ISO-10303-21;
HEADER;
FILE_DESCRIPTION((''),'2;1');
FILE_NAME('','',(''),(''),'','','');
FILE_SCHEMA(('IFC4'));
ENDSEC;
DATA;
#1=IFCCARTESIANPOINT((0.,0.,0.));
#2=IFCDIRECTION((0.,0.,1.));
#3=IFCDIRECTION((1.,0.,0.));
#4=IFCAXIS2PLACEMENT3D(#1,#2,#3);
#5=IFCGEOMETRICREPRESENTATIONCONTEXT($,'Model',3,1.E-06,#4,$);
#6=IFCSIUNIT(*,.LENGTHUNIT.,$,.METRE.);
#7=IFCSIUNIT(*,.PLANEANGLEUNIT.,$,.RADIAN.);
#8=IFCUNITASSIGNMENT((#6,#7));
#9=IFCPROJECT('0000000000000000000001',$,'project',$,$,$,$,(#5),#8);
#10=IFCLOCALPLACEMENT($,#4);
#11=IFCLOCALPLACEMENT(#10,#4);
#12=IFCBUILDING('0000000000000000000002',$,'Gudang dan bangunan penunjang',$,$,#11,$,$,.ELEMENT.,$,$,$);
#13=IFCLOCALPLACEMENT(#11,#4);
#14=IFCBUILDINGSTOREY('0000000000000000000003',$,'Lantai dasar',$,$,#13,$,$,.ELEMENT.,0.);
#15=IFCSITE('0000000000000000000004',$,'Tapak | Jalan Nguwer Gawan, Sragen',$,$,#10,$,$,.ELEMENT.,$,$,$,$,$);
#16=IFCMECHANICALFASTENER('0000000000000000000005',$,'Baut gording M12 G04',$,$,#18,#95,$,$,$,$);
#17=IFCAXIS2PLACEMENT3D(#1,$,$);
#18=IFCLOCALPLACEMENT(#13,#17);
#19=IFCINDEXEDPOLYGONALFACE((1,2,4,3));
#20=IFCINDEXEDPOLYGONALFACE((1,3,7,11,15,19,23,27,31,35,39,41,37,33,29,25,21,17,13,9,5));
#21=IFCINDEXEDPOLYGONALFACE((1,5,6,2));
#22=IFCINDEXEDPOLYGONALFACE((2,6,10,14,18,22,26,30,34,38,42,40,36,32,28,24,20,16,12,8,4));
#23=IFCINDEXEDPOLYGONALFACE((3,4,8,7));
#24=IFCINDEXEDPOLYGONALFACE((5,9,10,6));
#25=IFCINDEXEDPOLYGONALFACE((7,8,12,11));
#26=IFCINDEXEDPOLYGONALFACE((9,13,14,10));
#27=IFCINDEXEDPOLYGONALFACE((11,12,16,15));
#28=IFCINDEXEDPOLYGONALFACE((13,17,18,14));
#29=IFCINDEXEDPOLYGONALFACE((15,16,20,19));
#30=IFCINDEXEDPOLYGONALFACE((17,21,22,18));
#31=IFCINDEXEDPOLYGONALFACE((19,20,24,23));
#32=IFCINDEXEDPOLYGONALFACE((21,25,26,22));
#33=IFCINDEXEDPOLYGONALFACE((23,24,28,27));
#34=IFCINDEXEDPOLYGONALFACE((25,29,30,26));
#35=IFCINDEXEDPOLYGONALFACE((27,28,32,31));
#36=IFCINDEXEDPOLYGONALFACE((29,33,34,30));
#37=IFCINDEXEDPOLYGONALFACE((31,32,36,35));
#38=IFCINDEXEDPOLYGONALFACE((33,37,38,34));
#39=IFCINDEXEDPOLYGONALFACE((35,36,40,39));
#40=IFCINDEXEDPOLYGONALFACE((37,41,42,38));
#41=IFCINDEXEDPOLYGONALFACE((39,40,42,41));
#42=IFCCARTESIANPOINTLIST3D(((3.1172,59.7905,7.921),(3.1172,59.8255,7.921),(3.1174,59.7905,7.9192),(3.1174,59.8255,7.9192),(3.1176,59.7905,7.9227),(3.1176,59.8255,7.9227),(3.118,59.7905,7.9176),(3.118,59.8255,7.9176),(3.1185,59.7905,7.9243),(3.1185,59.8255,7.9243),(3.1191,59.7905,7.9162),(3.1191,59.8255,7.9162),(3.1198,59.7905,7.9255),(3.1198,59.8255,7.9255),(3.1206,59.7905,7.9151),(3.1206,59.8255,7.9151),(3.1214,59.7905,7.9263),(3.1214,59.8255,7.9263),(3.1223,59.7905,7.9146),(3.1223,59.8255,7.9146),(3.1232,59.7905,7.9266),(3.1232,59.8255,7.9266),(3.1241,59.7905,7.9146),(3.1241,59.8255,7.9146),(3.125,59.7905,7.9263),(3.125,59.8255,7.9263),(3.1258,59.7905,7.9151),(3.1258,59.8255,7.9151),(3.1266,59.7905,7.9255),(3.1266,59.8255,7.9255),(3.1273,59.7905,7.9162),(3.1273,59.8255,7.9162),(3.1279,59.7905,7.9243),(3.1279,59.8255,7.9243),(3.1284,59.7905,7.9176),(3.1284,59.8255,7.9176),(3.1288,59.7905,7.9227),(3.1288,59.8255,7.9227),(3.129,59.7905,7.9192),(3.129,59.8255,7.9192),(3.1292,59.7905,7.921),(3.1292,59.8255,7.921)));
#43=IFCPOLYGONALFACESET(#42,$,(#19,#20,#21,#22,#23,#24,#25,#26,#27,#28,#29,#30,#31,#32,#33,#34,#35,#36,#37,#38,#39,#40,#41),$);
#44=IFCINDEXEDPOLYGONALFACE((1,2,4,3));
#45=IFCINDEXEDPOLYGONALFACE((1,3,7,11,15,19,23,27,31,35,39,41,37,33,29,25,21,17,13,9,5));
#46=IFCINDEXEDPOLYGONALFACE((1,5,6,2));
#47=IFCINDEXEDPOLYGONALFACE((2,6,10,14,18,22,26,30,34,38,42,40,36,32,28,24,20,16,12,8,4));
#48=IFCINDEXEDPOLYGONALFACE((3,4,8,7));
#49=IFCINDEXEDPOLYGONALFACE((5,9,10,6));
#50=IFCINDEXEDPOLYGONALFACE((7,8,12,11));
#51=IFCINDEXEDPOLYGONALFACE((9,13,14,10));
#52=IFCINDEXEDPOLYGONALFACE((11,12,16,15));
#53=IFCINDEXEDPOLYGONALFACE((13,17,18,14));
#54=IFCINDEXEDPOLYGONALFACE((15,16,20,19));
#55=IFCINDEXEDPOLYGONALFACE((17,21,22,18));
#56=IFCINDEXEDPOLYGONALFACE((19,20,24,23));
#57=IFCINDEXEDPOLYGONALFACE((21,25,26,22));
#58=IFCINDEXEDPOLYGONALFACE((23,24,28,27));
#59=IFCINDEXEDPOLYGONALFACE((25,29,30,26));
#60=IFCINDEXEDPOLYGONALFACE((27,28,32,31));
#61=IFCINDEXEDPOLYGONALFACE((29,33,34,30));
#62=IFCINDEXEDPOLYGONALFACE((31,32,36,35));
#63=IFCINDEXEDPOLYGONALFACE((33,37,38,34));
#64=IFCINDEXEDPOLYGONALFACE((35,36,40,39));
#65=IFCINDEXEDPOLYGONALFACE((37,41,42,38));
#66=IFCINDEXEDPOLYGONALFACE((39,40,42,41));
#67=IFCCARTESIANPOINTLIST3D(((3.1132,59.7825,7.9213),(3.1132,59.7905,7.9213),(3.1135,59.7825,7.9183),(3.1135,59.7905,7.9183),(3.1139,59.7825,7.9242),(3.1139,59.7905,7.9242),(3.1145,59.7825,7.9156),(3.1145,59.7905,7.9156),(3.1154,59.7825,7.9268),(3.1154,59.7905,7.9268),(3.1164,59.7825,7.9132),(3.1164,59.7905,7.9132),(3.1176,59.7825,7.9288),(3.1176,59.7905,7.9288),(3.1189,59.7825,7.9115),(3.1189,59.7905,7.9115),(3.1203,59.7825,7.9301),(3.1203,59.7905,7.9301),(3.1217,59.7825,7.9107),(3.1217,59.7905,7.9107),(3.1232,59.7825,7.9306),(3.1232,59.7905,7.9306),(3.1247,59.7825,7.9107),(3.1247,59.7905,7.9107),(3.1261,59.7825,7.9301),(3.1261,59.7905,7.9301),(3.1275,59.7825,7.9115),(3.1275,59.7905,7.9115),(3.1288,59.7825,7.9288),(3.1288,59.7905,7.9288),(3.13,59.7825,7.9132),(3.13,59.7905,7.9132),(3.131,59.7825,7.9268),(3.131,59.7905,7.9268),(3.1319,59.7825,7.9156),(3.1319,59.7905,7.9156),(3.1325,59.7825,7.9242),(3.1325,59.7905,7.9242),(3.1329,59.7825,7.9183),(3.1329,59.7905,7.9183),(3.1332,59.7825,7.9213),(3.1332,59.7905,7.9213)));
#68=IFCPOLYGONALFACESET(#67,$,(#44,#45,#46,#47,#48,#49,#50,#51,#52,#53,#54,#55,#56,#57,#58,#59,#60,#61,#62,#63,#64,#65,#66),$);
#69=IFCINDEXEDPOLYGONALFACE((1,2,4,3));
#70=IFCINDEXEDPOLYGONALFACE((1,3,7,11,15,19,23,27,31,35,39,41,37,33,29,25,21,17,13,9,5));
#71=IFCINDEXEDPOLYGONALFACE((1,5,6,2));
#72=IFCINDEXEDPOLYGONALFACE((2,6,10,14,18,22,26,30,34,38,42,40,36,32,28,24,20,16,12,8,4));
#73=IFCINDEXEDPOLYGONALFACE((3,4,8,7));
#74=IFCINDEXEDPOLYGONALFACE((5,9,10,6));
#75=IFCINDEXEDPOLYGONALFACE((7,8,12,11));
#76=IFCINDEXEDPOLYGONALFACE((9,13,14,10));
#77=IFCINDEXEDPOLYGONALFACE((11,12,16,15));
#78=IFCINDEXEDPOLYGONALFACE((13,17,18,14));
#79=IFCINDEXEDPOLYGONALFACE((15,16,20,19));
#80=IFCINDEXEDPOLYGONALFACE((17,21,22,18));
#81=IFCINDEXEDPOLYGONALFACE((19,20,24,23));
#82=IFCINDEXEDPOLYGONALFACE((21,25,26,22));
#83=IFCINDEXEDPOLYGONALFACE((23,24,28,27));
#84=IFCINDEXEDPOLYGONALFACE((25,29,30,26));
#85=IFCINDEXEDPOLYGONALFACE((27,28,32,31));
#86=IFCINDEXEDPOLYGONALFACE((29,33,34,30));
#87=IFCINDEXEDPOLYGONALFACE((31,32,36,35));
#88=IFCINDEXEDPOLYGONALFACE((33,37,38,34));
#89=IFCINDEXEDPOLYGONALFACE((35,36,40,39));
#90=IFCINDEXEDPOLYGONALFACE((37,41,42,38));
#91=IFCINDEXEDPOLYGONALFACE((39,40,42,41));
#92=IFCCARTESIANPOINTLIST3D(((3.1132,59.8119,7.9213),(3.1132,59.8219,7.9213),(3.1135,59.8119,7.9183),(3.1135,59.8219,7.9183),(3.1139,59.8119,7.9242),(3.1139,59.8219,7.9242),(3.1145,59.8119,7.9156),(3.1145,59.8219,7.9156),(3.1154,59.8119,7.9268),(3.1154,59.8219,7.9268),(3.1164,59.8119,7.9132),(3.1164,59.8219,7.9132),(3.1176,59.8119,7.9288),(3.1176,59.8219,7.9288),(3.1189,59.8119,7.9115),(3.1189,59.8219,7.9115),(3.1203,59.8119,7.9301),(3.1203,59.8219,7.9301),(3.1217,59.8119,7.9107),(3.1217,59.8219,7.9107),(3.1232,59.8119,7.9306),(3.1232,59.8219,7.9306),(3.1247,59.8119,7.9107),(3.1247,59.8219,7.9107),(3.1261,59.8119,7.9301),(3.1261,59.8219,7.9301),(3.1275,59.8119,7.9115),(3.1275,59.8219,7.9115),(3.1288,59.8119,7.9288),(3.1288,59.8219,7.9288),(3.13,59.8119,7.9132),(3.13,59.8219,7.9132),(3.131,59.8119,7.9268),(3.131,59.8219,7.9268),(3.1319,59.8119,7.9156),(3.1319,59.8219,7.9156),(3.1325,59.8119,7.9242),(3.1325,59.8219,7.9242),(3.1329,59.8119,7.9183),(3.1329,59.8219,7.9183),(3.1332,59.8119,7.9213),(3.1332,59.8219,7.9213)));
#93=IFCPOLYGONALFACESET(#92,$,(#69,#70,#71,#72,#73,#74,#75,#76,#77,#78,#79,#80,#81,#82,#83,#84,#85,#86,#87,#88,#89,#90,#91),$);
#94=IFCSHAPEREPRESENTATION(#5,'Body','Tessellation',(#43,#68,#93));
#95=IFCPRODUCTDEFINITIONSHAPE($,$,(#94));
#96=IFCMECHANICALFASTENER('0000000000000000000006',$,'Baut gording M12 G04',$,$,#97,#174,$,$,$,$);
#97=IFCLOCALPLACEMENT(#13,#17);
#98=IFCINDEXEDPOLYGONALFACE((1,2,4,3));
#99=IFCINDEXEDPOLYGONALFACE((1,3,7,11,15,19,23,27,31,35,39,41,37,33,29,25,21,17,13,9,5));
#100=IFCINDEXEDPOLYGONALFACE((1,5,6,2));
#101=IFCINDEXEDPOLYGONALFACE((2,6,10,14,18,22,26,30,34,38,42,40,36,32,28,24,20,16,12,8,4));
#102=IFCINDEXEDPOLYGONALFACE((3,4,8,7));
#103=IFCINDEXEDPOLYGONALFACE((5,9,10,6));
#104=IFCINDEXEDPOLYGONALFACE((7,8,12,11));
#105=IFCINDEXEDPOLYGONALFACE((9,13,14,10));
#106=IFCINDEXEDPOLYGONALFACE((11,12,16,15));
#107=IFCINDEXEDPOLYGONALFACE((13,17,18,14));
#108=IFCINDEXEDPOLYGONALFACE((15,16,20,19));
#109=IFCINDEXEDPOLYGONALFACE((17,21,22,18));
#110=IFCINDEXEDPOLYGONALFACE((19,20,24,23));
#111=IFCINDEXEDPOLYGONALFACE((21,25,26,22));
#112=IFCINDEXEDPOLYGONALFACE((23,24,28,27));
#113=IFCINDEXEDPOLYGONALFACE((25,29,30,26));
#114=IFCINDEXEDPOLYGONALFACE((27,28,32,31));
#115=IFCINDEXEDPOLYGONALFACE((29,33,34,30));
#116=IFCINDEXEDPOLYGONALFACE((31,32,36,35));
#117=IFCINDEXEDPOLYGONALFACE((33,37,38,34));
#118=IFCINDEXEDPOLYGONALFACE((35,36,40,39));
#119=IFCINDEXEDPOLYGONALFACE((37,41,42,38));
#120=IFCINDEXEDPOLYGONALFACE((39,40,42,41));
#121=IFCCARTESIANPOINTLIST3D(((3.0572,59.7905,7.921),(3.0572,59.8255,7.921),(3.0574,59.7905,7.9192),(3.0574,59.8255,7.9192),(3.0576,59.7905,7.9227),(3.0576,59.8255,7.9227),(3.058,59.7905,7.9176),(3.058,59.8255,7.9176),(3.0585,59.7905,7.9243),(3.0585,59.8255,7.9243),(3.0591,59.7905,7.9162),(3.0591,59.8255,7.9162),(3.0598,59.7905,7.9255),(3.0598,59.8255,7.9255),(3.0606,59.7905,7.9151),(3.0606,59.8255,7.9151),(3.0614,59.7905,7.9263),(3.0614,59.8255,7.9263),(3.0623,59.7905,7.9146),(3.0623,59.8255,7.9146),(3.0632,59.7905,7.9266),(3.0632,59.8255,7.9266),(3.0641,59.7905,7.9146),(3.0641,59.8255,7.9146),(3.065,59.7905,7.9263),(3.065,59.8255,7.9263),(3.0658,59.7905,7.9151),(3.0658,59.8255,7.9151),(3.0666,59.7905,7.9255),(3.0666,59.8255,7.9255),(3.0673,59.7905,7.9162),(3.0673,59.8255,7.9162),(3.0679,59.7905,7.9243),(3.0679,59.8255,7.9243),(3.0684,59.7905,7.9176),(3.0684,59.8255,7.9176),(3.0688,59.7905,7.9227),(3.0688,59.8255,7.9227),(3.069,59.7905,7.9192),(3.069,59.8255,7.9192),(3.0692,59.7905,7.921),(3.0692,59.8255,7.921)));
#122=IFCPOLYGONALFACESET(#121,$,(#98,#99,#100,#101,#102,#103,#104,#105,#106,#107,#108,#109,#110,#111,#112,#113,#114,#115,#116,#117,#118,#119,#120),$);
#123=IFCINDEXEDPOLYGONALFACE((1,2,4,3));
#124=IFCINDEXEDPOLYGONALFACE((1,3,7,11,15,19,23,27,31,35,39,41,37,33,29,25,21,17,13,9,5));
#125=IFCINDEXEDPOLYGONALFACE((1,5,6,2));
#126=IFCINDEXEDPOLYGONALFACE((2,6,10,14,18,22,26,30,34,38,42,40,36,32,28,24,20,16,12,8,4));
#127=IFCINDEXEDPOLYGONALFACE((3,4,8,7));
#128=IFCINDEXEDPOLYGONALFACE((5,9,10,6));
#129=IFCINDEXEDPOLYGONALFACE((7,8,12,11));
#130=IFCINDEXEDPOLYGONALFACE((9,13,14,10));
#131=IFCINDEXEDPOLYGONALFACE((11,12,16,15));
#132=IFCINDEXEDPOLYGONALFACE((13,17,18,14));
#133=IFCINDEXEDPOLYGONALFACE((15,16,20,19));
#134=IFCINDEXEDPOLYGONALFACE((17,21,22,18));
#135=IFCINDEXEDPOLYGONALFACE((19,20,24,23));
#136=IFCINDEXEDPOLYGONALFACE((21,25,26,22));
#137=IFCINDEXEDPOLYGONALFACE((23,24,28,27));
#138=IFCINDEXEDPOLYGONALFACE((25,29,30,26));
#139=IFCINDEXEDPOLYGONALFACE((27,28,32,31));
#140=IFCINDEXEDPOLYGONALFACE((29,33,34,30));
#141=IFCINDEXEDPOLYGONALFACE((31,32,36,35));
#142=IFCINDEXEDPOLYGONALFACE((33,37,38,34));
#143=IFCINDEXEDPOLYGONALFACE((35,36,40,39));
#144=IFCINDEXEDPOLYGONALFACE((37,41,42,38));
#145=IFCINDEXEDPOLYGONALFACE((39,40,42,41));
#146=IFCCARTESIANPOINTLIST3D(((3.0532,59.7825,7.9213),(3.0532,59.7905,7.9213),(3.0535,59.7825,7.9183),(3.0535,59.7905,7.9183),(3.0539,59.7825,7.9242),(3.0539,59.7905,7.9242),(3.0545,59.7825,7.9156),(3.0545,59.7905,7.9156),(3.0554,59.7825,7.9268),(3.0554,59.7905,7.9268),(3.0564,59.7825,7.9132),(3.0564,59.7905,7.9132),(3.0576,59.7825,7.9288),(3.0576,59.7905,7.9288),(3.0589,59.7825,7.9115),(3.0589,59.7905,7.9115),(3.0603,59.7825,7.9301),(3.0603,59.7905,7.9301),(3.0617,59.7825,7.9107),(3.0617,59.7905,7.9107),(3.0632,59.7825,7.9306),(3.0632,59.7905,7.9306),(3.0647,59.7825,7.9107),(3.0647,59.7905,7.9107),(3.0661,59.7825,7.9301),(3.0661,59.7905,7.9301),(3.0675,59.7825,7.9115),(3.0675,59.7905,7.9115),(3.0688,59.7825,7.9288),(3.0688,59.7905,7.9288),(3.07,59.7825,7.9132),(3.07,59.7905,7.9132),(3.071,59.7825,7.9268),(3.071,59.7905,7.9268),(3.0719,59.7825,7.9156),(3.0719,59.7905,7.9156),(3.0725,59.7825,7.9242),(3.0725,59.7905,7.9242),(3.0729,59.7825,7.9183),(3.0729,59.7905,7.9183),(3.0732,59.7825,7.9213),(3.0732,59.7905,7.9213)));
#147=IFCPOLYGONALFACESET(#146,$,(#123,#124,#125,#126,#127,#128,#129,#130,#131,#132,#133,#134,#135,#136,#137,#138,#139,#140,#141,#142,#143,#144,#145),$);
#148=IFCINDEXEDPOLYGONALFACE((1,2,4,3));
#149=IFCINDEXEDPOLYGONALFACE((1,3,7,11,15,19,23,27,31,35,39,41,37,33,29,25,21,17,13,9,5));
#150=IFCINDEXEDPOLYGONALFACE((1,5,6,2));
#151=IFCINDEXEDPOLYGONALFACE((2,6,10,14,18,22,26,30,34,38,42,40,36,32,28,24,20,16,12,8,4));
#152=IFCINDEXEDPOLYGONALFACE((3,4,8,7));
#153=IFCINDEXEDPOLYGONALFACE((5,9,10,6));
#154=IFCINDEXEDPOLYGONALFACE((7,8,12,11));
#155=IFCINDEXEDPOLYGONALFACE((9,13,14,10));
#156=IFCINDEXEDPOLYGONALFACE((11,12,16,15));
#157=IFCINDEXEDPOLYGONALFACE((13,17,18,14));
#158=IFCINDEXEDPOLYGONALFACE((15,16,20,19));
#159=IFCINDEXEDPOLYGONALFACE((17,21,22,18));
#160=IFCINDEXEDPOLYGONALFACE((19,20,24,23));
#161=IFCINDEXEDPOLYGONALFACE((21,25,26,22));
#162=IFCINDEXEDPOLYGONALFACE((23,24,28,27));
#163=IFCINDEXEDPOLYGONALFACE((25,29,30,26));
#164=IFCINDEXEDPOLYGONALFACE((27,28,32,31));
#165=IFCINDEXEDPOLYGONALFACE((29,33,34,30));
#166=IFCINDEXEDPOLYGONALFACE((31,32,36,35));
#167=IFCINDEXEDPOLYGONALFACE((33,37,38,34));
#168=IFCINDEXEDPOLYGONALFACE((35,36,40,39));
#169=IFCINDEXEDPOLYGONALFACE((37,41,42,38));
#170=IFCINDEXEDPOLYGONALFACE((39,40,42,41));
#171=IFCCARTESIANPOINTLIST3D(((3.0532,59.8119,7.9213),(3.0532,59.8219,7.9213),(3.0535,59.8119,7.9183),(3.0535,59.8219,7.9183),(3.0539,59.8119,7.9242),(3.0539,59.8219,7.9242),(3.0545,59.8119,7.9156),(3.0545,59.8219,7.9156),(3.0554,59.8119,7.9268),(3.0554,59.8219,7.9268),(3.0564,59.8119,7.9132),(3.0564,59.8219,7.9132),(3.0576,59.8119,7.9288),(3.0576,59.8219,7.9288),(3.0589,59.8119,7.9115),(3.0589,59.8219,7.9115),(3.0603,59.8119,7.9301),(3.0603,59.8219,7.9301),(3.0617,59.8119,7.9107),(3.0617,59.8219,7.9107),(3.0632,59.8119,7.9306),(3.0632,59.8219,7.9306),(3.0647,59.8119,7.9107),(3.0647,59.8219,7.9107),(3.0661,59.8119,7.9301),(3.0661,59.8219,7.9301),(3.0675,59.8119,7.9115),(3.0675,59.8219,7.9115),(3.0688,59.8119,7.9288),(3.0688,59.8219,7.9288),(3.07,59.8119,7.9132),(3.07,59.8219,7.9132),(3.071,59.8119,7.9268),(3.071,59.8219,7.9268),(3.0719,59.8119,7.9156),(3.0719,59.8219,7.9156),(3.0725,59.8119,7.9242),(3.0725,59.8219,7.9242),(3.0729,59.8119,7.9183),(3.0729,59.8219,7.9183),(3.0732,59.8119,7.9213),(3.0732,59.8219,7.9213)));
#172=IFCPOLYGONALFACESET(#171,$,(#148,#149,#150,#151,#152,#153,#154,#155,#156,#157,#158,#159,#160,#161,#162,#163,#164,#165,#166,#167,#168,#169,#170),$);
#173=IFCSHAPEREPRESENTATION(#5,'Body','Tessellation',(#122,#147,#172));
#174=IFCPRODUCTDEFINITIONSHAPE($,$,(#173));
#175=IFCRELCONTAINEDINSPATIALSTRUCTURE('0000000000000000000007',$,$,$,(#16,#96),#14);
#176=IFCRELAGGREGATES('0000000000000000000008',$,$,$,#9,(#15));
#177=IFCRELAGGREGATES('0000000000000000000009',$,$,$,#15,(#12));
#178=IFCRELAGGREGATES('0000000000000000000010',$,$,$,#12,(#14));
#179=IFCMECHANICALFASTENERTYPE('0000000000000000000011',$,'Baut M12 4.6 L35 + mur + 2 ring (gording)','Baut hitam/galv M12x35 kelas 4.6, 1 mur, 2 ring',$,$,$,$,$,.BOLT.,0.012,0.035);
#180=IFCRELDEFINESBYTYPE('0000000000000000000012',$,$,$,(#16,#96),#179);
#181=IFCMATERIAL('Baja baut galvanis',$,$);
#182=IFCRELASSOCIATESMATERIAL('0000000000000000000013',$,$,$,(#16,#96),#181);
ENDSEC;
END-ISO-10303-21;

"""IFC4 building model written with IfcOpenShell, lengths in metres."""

from ifc_helpers import new_model, si_unit, frame, origin_with_axes, place, context, project, spatial, circle, extrude, source, transform, mapped, material, type_object, type_shapes, element, save


model = new_model("IFC4")

# Units and contexts
model_context = context("Model", 3, precision=1e-06, world=origin_with_axes())
ifc_project = project(units=[si_unit("LENGTHUNIT", "METRE"), si_unit("PLANEANGLEUNIT", "RADIAN")], contexts=[model_context])

# Site, building, storey
site_placement = place(None, origin_with_axes())
site = spatial("IfcSite", under=ifc_project, at=site_placement, Name="Tapak | Jalan Nguwer Gawan, Sragen", CompositionType="ELEMENT")
building_placement = place(site_placement, origin_with_axes())
building = spatial("IfcBuilding", under=site, at=building_placement, Name="Gudang dan bangunan penunjang", CompositionType="ELEMENT")
storey_placement = place(building_placement, origin_with_axes())
storey = spatial("IfcBuildingStorey", under=building, at=storey_placement, Name="Lantai dasar", CompositionType="ELEMENT", Elevation=0.0)

# Shared definitions
placement = place(None, origin_with_axes())

# Mechanical fasteners
ifc_material_1 = material(Name="Baja baut galvanis")
mechanical_fastener_type = type_object("IfcMechanicalFastenerType", Name="Baut M12 4.6 L35 + mur + 2 ring (gording)", Description="Baut hitam/galv M12x35 kelas 4.6, 1 mur, 2 ring", NominalDiameter=0.012, NominalLength=0.035, PredefinedType="BOLT")
shared_shape = source(origin_with_axes(), model_context, "Body", "SweptSolid", [
    extrude(circle(Radius=0.006), origin_with_axes(), (0.0, 0.0, 1.0), 0.035),
    extrude(circle(Radius=0.01), frame((0.0, 0.0, -0.008), z_axis=(0.0, 0.0, 1.0), x_axis=(1.0, 0.0, 0.0)), (0.0, 0.0, 1.0), 0.008),
    extrude(circle(Radius=0.01), frame((0.0, 0.0, 0.0214), z_axis=(0.0, 0.0, 1.0), x_axis=(1.0, 0.0, 0.0)), (0.0, 0.0, 1.0), 0.01),
])
type_shapes(mechanical_fastener_type, [shared_shape])
element("IfcMechanicalFastener", 1, at=placement, inside=storey, type_object=mechanical_fastener_type, material=ifc_material_1, Name="Baut gording M12 G04", context=model_context, shape_type="MappedRepresentation", body=[
    mapped(shared_shape, transform((3.1232, 59.7905, 7.9206), x_axis=(0.0, 0.0, 1.0), y_axis=(1.0, 0.0, 0.0), z_axis=(0.0, 1.0, 0.0), scale=1.0)),
])
element("IfcMechanicalFastener", 2, at=placement, inside=storey, type_object=mechanical_fastener_type, material=ifc_material_1, Name="Baut gording M12 G04", context=model_context, shape_type="MappedRepresentation", body=[
    mapped(shared_shape, transform((3.0632, 59.7905, 7.9206), x_axis=(0.0, 0.0, 1.0), y_axis=(1.0, 0.0, 0.0), z_axis=(0.0, 1.0, 0.0), scale=1.0)),
])

save(model, "model.ifc")
